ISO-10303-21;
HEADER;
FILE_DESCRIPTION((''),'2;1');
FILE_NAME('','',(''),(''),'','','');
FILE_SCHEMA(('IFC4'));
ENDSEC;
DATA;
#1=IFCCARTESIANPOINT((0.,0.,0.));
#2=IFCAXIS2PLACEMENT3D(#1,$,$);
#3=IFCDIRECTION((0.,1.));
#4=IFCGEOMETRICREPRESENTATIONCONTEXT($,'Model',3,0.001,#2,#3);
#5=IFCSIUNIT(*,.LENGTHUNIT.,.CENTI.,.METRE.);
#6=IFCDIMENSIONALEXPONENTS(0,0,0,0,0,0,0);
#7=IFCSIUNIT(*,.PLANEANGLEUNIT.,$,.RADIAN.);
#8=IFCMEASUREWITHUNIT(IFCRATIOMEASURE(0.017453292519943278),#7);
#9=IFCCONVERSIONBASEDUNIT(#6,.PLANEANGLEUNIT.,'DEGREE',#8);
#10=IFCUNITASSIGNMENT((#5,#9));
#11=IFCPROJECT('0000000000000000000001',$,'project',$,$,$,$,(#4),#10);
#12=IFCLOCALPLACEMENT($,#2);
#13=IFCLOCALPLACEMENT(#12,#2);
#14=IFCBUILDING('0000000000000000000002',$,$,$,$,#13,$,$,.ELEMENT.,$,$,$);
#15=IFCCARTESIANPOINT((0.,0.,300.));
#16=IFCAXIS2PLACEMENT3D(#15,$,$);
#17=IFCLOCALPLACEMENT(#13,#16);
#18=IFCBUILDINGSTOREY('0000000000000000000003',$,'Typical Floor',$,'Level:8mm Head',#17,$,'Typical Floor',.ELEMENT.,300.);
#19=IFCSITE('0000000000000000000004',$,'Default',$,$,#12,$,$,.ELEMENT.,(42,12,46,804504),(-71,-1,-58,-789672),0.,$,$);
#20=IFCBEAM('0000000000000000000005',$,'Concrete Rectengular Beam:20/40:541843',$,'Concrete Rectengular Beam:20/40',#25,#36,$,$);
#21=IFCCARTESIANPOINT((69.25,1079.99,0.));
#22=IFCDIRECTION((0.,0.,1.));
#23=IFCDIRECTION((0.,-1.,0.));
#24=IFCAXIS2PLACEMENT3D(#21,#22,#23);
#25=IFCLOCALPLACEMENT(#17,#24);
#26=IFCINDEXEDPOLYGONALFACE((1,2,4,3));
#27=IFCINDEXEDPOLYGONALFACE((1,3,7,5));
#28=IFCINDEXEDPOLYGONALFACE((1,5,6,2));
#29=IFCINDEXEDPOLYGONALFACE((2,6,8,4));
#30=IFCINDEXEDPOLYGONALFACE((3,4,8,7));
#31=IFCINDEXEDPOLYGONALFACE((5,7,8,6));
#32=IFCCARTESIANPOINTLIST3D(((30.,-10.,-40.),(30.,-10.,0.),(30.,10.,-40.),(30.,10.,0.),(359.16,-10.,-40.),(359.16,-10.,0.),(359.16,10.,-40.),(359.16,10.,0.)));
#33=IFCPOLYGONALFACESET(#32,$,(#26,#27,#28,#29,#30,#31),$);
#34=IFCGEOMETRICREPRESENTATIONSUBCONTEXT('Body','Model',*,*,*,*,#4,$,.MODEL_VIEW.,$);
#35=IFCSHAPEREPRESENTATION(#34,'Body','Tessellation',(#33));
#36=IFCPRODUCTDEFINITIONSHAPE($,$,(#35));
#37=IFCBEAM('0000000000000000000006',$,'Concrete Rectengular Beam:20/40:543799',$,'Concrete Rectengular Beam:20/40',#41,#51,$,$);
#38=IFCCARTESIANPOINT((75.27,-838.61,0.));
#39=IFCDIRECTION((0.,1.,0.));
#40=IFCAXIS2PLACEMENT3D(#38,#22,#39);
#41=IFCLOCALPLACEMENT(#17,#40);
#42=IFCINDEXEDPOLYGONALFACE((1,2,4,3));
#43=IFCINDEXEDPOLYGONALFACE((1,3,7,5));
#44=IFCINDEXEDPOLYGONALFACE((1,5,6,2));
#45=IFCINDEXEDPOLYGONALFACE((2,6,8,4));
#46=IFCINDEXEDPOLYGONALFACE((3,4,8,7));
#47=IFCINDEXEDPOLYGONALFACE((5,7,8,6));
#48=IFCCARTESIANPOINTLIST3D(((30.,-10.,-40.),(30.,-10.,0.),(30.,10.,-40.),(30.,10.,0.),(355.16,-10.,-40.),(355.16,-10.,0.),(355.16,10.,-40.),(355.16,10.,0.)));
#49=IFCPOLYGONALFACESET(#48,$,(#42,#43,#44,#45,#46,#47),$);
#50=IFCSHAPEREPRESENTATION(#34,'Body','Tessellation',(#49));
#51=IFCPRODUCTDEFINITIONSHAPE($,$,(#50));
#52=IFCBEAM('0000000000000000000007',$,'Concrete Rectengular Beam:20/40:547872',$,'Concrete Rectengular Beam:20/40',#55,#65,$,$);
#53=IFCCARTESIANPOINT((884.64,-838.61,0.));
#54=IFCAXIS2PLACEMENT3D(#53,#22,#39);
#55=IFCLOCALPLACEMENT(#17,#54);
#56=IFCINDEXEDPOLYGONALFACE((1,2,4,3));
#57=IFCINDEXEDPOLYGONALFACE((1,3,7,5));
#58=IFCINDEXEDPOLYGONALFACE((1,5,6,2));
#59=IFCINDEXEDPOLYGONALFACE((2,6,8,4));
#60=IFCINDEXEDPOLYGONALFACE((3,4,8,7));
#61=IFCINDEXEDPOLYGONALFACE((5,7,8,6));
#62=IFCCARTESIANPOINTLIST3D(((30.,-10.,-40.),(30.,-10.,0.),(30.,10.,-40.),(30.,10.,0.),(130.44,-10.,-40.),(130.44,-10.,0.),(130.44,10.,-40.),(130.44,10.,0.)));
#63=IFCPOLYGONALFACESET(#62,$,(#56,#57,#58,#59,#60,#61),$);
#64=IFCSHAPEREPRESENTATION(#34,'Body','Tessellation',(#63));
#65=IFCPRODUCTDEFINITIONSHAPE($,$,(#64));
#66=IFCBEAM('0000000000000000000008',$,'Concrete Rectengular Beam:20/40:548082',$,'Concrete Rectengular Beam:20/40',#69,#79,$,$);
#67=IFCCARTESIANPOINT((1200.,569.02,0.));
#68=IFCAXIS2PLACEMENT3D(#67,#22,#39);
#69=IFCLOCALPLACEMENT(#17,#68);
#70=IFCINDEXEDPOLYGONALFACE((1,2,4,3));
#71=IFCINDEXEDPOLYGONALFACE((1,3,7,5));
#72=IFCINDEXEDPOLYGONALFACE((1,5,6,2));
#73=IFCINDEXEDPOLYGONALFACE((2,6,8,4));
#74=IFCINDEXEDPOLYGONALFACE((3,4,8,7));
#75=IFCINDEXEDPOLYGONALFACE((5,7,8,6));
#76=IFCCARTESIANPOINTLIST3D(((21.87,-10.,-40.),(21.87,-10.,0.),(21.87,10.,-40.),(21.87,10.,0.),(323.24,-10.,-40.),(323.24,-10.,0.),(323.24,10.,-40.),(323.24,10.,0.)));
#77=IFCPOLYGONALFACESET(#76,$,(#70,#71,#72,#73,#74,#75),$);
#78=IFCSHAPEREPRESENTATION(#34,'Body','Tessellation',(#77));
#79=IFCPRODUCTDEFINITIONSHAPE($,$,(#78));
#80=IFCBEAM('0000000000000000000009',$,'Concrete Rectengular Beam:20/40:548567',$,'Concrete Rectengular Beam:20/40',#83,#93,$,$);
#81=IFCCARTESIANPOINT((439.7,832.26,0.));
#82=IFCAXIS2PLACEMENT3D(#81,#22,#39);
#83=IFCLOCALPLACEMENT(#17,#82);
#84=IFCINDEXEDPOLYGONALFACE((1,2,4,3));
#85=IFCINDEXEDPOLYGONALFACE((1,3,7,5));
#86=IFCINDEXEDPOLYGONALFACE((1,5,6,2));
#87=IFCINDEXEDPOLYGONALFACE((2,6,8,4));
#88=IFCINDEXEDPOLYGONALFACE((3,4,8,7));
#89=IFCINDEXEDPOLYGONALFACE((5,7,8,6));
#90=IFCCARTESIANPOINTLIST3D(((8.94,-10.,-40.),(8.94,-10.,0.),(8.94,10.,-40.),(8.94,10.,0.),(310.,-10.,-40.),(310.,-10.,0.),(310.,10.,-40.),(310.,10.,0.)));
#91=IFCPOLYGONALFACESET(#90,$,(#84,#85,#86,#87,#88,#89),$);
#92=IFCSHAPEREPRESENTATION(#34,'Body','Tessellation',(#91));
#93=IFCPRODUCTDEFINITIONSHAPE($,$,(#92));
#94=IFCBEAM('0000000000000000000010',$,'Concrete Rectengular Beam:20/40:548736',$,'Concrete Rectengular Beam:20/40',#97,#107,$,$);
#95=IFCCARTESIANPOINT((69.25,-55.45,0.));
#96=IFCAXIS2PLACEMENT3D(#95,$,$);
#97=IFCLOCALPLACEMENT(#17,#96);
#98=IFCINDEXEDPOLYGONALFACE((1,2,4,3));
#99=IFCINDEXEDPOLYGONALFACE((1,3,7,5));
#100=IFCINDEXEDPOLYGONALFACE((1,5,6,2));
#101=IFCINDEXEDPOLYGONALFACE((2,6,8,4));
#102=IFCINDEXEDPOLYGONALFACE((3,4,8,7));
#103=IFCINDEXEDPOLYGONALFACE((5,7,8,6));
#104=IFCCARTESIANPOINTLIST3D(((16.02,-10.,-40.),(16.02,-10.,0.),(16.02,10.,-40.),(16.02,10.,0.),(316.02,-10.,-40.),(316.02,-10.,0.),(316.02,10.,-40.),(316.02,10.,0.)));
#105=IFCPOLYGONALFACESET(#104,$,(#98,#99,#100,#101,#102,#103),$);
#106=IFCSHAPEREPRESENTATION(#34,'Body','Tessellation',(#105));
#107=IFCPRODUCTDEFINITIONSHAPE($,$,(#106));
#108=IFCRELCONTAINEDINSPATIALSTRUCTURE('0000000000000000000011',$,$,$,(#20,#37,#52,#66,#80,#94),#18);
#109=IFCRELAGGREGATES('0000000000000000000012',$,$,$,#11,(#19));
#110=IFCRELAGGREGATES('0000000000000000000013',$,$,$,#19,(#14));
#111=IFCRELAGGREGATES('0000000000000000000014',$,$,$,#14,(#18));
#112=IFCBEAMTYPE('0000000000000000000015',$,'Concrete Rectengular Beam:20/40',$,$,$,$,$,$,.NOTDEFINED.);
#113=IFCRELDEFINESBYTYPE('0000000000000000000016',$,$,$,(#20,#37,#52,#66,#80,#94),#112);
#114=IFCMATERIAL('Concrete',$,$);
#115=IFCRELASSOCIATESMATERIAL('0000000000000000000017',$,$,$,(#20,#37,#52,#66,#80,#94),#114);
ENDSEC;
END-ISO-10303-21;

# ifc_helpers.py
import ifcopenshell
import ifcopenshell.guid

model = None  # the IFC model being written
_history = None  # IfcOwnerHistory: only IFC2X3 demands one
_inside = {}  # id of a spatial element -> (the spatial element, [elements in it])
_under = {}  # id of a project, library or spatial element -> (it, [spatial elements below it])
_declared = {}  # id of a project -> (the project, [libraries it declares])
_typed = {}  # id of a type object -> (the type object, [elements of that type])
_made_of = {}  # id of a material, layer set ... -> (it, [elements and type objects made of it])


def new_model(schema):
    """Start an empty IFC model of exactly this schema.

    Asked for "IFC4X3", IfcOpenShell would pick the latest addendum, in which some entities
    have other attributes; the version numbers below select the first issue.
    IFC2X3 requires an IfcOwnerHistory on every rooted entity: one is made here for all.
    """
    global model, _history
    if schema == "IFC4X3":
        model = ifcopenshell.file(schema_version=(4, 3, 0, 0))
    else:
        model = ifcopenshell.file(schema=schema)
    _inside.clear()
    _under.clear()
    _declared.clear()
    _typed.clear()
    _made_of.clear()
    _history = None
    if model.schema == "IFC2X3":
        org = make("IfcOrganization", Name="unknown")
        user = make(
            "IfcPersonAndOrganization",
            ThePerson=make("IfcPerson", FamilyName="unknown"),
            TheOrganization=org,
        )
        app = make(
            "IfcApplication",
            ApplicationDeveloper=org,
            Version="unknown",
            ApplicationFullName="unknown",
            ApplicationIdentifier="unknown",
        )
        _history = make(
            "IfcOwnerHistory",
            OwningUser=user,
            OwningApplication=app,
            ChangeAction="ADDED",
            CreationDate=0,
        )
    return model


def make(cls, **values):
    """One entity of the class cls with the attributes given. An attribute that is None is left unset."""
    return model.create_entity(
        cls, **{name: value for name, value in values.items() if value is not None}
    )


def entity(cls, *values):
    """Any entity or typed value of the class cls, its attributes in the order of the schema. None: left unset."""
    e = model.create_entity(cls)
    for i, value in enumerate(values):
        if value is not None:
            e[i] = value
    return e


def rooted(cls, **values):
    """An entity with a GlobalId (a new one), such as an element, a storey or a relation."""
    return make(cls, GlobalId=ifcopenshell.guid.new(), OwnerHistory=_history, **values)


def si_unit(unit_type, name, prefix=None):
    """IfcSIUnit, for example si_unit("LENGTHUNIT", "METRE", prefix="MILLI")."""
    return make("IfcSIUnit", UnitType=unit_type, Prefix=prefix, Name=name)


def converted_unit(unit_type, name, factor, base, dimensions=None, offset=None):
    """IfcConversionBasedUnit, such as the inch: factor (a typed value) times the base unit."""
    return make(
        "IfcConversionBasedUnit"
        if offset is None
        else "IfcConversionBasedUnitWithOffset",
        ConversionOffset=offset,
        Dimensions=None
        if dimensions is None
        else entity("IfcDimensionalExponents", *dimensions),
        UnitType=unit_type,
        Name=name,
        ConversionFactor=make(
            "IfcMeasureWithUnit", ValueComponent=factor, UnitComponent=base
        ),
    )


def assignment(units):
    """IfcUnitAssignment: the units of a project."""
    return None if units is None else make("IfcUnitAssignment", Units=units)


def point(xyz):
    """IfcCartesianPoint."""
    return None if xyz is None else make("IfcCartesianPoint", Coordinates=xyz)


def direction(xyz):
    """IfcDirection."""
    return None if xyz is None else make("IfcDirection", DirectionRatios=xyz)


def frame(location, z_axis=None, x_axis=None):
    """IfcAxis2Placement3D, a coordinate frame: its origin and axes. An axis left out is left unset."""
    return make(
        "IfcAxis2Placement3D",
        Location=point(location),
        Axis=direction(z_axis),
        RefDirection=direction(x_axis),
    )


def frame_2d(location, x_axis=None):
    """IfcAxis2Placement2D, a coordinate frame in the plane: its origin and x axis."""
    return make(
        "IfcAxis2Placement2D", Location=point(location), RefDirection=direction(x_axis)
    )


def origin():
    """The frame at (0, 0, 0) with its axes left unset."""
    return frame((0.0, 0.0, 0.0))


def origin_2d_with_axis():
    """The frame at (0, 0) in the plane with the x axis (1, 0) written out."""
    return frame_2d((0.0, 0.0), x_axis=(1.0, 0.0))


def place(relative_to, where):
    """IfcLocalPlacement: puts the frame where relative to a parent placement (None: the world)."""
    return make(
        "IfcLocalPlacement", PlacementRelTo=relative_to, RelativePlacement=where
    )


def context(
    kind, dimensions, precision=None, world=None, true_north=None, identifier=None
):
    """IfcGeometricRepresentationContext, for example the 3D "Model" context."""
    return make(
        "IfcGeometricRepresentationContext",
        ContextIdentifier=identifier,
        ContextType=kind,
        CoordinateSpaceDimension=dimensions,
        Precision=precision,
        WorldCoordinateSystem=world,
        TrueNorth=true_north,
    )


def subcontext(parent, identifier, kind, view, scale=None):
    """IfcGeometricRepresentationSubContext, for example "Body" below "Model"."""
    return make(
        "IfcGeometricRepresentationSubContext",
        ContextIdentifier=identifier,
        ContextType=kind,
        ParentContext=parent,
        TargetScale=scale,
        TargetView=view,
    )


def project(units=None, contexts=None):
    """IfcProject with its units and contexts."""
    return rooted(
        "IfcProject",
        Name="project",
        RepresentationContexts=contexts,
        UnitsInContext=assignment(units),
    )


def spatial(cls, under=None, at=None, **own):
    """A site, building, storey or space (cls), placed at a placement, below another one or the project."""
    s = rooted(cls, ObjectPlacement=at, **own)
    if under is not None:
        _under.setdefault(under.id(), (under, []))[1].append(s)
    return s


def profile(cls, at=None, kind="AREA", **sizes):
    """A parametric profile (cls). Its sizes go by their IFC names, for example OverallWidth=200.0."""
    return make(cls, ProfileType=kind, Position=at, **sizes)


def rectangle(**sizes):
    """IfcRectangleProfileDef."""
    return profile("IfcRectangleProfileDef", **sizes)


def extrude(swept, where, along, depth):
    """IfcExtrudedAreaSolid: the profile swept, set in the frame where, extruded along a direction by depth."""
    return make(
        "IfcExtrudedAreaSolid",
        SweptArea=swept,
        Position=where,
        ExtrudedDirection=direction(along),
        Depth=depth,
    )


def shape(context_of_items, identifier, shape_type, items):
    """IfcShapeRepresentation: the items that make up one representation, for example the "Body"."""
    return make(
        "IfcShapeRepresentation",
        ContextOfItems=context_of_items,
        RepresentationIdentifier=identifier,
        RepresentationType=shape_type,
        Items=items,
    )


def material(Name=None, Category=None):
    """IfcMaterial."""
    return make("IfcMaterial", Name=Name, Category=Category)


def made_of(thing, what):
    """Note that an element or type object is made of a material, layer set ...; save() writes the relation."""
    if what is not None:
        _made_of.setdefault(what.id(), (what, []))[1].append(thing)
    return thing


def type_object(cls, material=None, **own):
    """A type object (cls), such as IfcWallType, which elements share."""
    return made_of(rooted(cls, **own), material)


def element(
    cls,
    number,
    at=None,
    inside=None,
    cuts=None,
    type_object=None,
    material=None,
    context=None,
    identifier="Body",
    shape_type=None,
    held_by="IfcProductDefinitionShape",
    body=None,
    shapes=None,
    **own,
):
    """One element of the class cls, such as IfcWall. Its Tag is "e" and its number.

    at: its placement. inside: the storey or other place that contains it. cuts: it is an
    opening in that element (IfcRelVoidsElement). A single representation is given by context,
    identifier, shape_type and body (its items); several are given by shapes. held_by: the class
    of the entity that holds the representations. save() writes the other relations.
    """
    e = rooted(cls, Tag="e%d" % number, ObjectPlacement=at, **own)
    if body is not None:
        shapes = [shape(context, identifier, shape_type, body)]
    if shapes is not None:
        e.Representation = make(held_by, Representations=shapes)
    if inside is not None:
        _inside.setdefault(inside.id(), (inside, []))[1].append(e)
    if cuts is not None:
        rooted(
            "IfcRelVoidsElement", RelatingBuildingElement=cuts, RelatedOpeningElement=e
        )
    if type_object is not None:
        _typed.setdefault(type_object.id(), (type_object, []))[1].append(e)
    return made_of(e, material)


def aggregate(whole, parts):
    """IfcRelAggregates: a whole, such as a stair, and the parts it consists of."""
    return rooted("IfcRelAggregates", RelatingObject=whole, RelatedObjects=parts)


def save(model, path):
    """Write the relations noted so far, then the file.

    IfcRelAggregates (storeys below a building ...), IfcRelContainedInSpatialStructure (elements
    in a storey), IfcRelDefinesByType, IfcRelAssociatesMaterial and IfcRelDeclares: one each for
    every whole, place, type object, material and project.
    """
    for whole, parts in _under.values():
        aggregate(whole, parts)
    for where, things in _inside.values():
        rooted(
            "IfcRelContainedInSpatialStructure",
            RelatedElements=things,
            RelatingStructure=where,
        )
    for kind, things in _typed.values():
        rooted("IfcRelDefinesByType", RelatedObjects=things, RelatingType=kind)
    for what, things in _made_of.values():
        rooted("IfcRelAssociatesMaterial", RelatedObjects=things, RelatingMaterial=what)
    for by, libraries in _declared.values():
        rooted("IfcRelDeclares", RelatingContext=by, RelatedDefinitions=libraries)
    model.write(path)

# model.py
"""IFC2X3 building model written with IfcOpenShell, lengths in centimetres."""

from ifc_helpers import new_model, entity, si_unit, converted_unit, direction, frame, frame_2d, origin, origin_2d_with_axis, place, context, subcontext, project, spatial, rectangle, extrude, material, type_object, element, save


model = new_model("IFC2X3")

# Units and contexts
model_context = context("Model", 3, precision=0.001, world=origin(), true_north=direction((0.0, 1.0)))
body_context = subcontext(model_context, "Body", "Model", "MODEL_VIEW")
ifc_project = project(units=[si_unit("LENGTHUNIT", "METRE", prefix="CENTI"), converted_unit("PLANEANGLEUNIT", "DEGREE", entity("IfcRatioMeasure", 0.017453292519943278), si_unit("PLANEANGLEUNIT", "RADIAN"), dimensions=[0, 0, 0, 0, 0, 0, 0])], contexts=[model_context])

# Site, building, storey
site_placement = place(None, origin())
site = spatial("IfcSite", under=ifc_project, at=site_placement, Name="Default", CompositionType="ELEMENT", RefLatitude=(42, 12, 46, 804504), RefLongitude=(-71, -1, -58, -789672), RefElevation=0.0)
building_placement = place(site_placement, origin())
building = spatial("IfcBuilding", under=site, at=building_placement, CompositionType="ELEMENT")
storey_placement = place(building_placement, frame((0.0, 0.0, 300.0)))
storey = spatial("IfcBuildingStorey", under=building, at=storey_placement, Name="Typical Floor", ObjectType="Level:8mm Head", LongName="Typical Floor", CompositionType="ELEMENT", Elevation=300.0)

# Beams
ifc_material = material(Name="Concrete")
beam_type = type_object("IfcBeamType", Name="Concrete Rectengular Beam:20/40", PredefinedType="NOTDEFINED")
beam_1_placement = place(storey_placement, frame((69.25, 1079.99, 0.0), z_axis=(0.0, 0.0, 1.0), x_axis=(0.0, -1.0, 0.0)))
element("IfcBeam", 1, at=beam_1_placement, inside=storey, type_object=beam_type, material=ifc_material, Name="Concrete Rectengular Beam:20/40:541843", ObjectType="Concrete Rectengular Beam:20/40", context=body_context, shape_type="SweptSolid", body=[
    extrude(rectangle(XDim=40.0, YDim=20.0, at=frame_2d((0.0, 0.0), x_axis=(1.0, 0.0))), frame((30.0, 0.0, -20.0), z_axis=(1.0, 0.0, 0.0), x_axis=(0.0, 0.0, -1.0)), (0.0, 0.0, 1.0), 329.16),
])
beam_2_placement = place(storey_placement, frame((75.27, -838.61, 0.0), z_axis=(0.0, 0.0, 1.0), x_axis=(0.0, 1.0, 0.0)))
element("IfcBeam", 2, at=beam_2_placement, inside=storey, type_object=beam_type, material=ifc_material, Name="Concrete Rectengular Beam:20/40:543799", ObjectType="Concrete Rectengular Beam:20/40", context=body_context, shape_type="SweptSolid", body=[
    extrude(rectangle(XDim=40.0, YDim=20.0, at=frame_2d((0.0, 0.0), x_axis=(1.0, 0.0))), frame((30.0, 0.0, -20.0), z_axis=(1.0, 0.0, 0.0), x_axis=(0.0, 0.0, -1.0)), (0.0, 0.0, 1.0), 325.16),
])
beam_3_placement = place(storey_placement, frame((884.64, -838.61, 0.0), z_axis=(0.0, 0.0, 1.0), x_axis=(0.0, 1.0, 0.0)))
element("IfcBeam", 3, at=beam_3_placement, inside=storey, type_object=beam_type, material=ifc_material, Name="Concrete Rectengular Beam:20/40:547872", ObjectType="Concrete Rectengular Beam:20/40", context=body_context, shape_type="SweptSolid", body=[
    extrude(rectangle(XDim=40.0, YDim=20.0, at=frame_2d((0.0, 0.0), x_axis=(1.0, 0.0))), frame((30.0, 0.0, -20.0), z_axis=(1.0, 0.0, 0.0), x_axis=(0.0, 0.0, -1.0)), (0.0, 0.0, 1.0), 100.44),
])
beam_4_placement = place(storey_placement, frame((1200.0, 569.02, 0.0), z_axis=(0.0, 0.0, 1.0), x_axis=(0.0, 1.0, 0.0)))
element("IfcBeam", 4, at=beam_4_placement, inside=storey, type_object=beam_type, material=ifc_material, Name="Concrete Rectengular Beam:20/40:548082", ObjectType="Concrete Rectengular Beam:20/40", context=body_context, shape_type="SweptSolid", body=[
    extrude(rectangle(XDim=40.0, YDim=20.0, at=frame_2d((0.0, 0.0), x_axis=(1.0, 0.0))), frame((21.87, 0.0, -20.0), z_axis=(1.0, 0.0, 0.0), x_axis=(0.0, 0.0, -1.0)), (0.0, 0.0, 1.0), 301.36),
])
beam_5_placement = place(storey_placement, frame((439.7, 832.26, 0.0), z_axis=(0.0, 0.0, 1.0), x_axis=(0.0, 1.0, 0.0)))
element("IfcBeam", 5, at=beam_5_placement, inside=storey, type_object=beam_type, material=ifc_material, Name="Concrete Rectengular Beam:20/40:548567", ObjectType="Concrete Rectengular Beam:20/40", context=body_context, shape_type="SweptSolid", body=[
    extrude(rectangle(XDim=40.0, YDim=20.0, at=origin_2d_with_axis()), frame((8.94, 0.0, -20.0), z_axis=(1.0, 0.0, 0.0), x_axis=(0.0, 0.0, -1.0)), (0.0, 0.0, 1.0), 301.06),
])
beam_6_placement = place(storey_placement, frame((69.25, -55.45, 0.0)))
element("IfcBeam", 6, at=beam_6_placement, inside=storey, type_object=beam_type, material=ifc_material, Name="Concrete Rectengular Beam:20/40:548736", ObjectType="Concrete Rectengular Beam:20/40", context=body_context, shape_type="SweptSolid", body=[
    extrude(rectangle(XDim=40.0, YDim=20.0, at=frame_2d((0.0, 0.0), x_axis=(1.0, 0.0))), frame((16.02, 0.0, -20.0), z_axis=(1.0, 0.0, 0.0), x_axis=(0.0, 0.0, -1.0)), (0.0, 0.0, 1.0), 300.0),
])

save(model, "model.ifc")
